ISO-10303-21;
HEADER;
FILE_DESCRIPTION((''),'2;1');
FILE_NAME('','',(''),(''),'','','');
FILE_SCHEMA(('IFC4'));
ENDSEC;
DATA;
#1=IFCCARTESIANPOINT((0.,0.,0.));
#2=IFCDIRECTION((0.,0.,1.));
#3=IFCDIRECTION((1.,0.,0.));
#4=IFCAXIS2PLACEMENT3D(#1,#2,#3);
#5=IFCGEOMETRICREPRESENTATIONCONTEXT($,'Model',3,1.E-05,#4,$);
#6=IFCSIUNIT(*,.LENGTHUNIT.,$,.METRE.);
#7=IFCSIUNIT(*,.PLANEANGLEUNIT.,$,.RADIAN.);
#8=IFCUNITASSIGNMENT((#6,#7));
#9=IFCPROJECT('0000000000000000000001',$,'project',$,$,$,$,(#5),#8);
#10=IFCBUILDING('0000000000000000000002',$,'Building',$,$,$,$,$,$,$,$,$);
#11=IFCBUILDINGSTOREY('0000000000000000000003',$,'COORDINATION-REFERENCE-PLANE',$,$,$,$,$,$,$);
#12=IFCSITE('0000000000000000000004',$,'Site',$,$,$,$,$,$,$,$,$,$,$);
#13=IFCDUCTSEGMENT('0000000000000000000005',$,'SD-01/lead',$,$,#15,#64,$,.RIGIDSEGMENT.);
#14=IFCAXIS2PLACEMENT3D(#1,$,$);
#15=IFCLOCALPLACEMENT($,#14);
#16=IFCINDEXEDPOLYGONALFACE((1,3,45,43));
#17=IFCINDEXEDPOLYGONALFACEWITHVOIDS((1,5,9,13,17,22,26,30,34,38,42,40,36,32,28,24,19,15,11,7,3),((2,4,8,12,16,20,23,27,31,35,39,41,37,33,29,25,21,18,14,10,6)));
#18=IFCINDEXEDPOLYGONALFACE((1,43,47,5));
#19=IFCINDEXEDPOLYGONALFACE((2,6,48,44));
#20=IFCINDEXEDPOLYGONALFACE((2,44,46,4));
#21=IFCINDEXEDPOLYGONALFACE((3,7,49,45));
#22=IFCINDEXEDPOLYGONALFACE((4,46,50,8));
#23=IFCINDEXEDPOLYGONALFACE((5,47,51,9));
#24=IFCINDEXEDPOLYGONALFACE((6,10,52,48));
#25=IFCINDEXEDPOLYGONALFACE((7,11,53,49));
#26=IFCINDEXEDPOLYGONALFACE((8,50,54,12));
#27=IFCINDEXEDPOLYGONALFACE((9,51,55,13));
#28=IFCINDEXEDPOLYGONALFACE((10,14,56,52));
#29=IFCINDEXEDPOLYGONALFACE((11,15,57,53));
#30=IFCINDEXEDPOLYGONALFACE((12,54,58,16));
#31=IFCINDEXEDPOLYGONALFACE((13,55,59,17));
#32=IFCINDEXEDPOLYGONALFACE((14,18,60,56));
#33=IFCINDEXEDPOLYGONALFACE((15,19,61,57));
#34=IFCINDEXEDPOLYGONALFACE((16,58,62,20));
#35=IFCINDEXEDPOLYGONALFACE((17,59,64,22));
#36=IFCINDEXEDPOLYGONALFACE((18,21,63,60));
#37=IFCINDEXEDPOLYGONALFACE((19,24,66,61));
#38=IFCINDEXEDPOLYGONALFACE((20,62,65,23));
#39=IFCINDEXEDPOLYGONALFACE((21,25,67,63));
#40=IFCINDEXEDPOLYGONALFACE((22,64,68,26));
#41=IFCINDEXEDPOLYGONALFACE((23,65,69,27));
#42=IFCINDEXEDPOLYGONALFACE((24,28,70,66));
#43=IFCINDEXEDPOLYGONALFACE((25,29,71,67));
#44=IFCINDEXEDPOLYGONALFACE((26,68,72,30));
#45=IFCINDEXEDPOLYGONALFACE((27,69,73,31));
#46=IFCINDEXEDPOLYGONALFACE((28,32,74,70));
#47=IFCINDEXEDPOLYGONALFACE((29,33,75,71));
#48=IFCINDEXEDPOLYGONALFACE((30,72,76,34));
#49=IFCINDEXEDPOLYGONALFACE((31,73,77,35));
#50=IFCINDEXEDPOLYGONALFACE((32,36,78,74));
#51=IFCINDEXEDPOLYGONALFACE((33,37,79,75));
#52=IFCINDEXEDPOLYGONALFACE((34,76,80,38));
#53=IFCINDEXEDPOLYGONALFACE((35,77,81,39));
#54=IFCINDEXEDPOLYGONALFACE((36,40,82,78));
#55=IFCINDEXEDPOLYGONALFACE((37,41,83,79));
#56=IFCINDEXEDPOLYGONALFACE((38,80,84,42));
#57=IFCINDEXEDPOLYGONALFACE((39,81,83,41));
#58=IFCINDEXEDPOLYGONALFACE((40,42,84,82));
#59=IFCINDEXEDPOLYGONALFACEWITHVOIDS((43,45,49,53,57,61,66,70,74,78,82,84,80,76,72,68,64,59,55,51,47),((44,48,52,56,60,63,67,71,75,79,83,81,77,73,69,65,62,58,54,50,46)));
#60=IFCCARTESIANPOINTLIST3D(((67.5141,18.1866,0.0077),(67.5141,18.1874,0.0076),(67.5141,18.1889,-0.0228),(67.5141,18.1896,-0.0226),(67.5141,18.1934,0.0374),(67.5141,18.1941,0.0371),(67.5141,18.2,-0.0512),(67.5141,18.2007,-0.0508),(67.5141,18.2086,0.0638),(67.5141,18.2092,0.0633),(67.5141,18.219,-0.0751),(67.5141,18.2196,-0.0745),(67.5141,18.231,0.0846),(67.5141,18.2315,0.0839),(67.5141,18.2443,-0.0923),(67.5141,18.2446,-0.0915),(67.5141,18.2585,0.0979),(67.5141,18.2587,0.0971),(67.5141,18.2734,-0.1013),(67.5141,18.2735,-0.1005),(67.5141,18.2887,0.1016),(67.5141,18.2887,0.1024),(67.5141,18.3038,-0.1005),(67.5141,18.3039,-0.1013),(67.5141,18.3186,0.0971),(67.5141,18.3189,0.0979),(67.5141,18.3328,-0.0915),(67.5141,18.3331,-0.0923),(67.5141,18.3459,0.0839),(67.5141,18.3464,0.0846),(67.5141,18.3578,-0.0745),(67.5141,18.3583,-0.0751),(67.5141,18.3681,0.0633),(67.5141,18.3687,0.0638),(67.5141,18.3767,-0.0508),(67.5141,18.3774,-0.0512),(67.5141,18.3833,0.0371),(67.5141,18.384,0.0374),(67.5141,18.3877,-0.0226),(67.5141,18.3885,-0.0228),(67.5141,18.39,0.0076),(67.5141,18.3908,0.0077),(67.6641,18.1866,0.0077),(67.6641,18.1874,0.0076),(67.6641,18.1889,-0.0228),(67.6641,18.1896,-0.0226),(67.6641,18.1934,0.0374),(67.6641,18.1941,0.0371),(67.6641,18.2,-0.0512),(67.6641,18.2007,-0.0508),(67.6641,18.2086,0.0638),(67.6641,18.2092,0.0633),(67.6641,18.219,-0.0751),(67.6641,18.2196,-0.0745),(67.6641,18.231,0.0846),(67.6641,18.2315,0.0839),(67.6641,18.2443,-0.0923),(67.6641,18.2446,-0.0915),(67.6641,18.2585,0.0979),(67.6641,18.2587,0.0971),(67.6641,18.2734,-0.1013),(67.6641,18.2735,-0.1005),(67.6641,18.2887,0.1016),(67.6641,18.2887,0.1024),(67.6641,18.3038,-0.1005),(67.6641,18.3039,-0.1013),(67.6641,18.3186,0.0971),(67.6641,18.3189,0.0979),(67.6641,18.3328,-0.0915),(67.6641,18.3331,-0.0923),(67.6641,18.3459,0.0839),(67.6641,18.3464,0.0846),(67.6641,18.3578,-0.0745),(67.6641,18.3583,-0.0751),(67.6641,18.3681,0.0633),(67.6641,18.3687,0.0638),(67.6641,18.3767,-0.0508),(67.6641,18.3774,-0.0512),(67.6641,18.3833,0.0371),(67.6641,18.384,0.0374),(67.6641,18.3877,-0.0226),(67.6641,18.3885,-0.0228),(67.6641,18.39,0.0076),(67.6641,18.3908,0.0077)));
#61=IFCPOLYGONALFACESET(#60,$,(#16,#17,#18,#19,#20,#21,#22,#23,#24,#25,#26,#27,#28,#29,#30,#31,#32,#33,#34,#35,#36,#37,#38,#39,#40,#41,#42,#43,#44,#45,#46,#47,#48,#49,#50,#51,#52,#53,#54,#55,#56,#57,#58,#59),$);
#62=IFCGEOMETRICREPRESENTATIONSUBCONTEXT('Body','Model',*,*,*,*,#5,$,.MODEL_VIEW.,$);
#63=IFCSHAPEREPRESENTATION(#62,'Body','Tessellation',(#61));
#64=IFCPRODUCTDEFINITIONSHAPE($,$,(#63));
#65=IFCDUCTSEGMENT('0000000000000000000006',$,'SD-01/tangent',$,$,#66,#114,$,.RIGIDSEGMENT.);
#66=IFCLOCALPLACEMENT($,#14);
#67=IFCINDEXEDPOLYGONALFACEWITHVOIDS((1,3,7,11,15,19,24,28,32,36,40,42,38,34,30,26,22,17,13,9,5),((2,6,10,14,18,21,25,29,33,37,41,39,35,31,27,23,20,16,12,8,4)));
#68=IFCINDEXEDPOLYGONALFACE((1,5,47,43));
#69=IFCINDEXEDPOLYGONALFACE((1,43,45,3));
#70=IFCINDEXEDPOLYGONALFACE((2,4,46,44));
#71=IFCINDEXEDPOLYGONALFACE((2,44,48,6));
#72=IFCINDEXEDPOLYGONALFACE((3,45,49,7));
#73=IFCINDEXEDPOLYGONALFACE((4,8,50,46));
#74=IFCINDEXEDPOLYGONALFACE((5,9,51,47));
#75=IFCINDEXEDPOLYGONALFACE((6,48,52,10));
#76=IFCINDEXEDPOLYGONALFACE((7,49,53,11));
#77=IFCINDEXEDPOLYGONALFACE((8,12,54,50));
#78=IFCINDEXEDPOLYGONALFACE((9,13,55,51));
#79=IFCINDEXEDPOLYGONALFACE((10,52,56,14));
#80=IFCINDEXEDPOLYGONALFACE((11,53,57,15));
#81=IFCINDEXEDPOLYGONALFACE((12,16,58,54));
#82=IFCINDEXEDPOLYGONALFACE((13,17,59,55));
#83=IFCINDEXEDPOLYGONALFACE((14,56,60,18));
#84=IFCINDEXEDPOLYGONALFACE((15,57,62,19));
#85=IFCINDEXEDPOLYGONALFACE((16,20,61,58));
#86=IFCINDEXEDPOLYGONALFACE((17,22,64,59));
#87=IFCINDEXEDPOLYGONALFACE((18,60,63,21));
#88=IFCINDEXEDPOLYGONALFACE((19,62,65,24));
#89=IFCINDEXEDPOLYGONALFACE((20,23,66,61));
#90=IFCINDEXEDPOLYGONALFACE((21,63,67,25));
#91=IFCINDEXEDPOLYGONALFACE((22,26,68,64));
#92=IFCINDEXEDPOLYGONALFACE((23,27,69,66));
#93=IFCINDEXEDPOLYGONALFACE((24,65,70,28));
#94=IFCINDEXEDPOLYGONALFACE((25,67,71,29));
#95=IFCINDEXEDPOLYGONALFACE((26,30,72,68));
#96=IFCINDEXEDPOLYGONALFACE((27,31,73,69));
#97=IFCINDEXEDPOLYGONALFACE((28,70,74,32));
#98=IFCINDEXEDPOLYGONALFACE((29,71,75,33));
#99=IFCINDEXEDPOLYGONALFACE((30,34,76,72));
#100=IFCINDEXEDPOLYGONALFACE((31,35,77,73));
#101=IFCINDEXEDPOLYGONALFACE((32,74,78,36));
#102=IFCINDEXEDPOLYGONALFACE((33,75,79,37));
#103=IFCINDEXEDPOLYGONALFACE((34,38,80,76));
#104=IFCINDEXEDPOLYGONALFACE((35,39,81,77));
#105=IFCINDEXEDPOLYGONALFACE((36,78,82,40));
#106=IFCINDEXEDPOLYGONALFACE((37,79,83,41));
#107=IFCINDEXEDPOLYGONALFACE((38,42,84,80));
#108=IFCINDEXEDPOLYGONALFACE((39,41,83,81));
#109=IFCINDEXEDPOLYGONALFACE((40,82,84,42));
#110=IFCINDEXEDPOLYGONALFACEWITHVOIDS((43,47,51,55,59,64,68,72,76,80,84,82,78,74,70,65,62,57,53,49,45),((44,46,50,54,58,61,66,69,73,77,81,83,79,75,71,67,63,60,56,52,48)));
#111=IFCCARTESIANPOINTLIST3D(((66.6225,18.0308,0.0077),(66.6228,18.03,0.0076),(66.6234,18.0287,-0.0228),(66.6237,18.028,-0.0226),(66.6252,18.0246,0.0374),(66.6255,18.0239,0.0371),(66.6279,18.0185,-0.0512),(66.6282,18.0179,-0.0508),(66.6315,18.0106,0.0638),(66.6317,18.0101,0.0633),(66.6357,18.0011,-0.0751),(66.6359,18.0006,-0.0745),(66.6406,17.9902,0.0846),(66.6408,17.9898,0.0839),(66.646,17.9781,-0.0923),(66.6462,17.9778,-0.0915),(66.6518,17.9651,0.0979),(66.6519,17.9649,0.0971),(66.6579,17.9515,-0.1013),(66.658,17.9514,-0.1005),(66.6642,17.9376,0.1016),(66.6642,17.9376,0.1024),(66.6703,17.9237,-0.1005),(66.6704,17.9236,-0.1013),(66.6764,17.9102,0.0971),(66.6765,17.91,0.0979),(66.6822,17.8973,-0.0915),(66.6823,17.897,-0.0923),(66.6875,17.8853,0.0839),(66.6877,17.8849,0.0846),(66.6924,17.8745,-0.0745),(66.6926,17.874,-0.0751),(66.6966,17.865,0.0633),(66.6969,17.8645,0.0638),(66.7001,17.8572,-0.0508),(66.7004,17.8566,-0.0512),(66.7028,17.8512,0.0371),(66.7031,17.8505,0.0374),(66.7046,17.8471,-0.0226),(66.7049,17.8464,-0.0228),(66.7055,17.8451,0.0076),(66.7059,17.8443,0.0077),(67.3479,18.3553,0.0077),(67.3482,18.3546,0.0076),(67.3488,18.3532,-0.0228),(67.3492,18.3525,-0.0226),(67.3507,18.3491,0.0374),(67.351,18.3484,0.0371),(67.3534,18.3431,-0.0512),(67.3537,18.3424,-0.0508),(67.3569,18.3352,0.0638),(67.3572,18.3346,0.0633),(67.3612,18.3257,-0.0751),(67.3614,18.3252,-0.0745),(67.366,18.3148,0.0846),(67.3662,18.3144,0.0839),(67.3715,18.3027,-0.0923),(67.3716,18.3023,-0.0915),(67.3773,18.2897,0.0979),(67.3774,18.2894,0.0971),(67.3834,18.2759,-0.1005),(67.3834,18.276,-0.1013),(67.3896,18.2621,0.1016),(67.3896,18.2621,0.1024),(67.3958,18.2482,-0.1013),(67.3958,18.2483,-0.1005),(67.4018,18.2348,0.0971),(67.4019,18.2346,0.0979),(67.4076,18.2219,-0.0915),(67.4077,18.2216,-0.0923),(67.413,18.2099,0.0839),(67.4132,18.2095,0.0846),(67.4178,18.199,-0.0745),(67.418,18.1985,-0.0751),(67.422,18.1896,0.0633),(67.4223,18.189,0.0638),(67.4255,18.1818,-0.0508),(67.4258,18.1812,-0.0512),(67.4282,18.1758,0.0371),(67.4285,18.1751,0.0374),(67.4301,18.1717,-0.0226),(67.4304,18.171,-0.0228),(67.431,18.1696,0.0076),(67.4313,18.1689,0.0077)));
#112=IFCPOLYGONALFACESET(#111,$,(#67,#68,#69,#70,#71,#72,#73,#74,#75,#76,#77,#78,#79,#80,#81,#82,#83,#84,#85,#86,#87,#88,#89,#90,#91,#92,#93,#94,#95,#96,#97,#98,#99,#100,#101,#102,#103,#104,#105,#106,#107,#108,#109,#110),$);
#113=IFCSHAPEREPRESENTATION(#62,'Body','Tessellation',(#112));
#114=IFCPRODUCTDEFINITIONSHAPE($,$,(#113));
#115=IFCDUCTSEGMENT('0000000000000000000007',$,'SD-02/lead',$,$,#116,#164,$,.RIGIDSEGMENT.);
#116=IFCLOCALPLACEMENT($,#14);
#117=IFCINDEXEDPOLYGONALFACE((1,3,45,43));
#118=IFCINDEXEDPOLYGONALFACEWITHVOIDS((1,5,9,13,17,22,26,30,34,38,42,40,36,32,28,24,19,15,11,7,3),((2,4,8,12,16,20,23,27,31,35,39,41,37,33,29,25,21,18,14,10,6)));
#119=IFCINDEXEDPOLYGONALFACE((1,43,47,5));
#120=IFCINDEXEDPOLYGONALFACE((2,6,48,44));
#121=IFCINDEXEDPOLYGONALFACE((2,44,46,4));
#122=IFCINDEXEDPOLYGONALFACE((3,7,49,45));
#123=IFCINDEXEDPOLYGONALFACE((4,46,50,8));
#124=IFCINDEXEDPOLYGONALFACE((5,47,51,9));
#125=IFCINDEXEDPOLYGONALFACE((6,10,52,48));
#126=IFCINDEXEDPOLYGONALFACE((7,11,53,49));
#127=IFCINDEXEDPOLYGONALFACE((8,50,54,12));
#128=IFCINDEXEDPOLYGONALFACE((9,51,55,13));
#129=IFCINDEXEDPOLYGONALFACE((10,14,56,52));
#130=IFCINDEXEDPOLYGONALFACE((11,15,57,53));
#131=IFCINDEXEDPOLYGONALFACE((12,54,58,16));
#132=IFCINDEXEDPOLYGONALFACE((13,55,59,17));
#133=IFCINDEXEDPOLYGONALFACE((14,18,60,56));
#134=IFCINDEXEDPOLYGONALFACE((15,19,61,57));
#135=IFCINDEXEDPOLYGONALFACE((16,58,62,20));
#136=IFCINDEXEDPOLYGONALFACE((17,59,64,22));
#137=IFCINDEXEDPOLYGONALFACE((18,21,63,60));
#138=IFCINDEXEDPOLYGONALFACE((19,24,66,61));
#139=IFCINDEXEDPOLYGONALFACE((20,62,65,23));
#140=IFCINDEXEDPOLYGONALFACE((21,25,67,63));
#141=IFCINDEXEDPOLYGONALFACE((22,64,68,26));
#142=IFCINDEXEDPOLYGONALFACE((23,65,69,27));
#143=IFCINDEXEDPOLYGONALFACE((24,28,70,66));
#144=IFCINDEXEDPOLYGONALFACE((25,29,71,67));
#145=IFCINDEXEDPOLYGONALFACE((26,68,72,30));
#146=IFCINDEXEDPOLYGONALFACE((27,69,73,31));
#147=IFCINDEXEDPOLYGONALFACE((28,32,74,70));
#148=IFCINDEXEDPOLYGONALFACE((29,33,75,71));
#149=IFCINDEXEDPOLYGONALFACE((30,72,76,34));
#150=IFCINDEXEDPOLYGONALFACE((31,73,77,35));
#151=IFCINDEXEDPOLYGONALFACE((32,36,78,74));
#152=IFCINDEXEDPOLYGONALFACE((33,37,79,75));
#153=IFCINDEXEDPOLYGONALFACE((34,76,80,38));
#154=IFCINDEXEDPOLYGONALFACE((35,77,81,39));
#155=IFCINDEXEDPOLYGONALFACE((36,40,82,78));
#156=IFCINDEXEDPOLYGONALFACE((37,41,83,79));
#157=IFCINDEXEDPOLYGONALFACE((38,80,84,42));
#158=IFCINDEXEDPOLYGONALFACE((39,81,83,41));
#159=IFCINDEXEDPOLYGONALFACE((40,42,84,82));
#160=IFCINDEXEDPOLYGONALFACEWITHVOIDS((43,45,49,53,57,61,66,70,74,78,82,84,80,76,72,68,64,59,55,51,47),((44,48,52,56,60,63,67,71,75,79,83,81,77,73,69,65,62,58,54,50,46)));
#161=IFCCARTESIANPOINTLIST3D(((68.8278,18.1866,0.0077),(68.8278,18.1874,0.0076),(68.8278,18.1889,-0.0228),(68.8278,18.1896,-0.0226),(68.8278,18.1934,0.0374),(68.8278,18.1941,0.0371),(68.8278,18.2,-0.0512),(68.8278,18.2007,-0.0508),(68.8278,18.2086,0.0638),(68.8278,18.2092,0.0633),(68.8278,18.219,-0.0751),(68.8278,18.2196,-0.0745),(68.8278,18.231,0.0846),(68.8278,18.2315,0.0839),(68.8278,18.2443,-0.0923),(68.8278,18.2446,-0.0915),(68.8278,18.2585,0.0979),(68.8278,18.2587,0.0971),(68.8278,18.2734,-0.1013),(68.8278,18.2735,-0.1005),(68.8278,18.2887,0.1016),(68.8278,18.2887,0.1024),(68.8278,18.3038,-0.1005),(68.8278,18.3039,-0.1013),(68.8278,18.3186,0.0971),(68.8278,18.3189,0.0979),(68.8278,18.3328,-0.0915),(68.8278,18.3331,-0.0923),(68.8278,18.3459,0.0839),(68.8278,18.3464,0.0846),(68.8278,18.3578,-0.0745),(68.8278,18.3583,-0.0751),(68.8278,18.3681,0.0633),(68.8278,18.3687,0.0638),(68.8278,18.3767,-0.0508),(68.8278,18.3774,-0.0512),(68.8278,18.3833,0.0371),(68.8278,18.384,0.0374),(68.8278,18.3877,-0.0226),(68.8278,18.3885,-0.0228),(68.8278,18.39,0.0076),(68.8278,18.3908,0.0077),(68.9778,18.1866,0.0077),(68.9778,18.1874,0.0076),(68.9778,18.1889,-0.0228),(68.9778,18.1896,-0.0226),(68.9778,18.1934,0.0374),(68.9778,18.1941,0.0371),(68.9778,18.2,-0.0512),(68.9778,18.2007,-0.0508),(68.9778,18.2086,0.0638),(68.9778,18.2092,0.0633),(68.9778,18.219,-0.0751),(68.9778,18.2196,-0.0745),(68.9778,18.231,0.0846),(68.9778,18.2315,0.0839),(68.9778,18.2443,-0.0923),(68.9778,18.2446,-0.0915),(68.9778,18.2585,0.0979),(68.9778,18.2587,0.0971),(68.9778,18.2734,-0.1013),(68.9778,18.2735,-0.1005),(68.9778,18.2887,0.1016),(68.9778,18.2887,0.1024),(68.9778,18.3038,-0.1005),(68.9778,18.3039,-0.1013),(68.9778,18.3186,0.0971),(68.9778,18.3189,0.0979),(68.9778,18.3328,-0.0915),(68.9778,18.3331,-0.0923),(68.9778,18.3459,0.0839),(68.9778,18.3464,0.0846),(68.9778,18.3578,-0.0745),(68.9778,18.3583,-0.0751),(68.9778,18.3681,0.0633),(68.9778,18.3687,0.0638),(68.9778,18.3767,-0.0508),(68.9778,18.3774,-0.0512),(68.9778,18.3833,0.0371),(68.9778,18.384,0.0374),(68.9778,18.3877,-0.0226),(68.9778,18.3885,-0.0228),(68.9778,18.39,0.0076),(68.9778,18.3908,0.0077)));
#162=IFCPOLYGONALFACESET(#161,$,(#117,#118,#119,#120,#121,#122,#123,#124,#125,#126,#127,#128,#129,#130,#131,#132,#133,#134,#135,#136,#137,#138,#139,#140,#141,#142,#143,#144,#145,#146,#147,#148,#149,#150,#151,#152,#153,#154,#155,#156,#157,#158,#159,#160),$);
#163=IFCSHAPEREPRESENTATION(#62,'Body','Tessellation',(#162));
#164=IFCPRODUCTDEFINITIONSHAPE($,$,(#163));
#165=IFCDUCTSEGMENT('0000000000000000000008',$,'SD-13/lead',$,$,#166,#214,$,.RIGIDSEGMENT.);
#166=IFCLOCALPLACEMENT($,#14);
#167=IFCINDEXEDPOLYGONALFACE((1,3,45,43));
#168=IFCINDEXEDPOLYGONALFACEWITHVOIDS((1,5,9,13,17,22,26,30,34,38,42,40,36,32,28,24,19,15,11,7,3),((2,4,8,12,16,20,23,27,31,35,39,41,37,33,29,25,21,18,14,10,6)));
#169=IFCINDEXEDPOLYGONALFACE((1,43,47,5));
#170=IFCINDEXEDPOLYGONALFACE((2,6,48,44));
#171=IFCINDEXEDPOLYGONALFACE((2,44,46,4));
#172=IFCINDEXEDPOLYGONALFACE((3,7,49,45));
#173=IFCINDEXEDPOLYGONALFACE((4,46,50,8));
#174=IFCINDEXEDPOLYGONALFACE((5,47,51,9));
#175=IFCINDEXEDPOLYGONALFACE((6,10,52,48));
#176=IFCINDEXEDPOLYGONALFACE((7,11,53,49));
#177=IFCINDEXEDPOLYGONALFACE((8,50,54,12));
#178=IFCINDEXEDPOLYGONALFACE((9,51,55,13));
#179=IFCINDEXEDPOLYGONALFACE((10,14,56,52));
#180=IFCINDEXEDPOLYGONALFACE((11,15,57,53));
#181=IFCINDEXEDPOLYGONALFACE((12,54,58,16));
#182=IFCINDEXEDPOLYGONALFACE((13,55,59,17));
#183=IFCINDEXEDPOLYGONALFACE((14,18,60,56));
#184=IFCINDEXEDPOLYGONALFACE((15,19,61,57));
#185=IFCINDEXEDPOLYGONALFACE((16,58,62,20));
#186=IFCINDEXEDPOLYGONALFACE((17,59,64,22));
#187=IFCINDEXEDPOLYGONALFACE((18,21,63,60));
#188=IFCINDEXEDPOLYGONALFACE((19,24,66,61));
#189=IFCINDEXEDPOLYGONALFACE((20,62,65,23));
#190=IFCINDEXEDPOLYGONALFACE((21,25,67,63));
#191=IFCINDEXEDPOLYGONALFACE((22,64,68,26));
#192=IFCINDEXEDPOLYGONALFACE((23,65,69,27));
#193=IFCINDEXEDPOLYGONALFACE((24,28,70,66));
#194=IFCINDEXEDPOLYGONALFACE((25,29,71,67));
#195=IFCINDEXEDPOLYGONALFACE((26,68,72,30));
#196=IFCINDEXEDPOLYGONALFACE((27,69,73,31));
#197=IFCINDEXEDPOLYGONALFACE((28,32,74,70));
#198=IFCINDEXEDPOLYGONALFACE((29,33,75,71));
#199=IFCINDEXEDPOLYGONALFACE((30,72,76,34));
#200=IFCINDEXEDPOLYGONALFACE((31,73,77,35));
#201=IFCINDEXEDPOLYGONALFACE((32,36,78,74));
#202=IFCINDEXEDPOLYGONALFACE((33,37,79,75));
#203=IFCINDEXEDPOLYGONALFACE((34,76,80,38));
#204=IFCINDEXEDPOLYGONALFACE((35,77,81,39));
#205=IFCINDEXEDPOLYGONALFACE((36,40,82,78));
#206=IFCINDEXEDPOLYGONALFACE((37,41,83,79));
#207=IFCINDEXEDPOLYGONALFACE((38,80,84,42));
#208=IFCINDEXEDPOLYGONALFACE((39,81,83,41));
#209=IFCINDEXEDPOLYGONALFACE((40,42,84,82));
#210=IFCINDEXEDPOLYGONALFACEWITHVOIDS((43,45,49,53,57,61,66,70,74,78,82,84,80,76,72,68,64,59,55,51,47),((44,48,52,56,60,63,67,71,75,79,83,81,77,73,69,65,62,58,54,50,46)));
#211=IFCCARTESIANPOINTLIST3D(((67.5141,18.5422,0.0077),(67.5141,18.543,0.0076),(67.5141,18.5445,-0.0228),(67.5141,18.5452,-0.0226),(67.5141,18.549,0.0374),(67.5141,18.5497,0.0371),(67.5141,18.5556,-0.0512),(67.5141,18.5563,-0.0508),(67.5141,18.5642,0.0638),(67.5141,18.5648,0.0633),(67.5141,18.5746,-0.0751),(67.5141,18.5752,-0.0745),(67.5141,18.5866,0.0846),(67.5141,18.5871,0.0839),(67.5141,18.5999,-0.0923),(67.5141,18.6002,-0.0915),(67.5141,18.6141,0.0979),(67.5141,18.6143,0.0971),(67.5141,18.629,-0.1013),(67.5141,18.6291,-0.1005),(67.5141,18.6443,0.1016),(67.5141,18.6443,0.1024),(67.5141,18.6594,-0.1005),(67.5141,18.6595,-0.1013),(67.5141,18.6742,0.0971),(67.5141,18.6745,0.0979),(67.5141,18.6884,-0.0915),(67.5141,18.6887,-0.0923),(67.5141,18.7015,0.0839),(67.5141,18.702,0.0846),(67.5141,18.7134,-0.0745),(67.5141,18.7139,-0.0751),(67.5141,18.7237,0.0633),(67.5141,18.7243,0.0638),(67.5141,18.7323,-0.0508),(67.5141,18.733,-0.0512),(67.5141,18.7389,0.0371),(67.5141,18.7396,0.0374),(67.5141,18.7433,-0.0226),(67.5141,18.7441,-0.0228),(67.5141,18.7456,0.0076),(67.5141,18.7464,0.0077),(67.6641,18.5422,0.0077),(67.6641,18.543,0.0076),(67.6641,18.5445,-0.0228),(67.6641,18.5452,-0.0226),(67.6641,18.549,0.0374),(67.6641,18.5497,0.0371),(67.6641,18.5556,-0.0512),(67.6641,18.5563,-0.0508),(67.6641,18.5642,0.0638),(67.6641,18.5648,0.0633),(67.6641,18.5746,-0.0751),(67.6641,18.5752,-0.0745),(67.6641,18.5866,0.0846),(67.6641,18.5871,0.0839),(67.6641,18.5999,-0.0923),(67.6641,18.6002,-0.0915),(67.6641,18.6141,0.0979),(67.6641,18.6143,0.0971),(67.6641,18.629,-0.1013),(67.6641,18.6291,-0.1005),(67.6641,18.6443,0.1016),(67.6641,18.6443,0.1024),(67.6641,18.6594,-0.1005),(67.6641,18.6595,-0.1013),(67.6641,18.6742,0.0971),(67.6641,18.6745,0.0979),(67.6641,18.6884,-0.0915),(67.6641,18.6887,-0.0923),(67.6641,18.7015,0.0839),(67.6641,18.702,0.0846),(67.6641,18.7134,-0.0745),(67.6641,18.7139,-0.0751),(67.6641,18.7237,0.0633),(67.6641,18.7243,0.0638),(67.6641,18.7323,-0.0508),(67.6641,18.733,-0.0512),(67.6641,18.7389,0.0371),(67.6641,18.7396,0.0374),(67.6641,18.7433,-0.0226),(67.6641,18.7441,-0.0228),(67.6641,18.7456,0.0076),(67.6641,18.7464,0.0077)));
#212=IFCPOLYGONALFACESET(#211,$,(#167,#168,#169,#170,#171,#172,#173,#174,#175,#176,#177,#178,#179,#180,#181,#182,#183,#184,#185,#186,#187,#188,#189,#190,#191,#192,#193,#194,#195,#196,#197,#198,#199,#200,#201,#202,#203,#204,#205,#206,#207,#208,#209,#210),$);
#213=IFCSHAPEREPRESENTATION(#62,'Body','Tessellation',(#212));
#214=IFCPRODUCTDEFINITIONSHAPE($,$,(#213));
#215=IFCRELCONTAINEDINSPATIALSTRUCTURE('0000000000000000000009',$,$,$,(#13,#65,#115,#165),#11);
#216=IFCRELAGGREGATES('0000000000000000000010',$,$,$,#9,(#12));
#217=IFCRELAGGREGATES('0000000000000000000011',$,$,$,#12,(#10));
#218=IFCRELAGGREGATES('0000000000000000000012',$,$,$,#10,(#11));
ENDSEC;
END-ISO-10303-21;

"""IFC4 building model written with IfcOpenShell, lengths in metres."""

from ifc_helpers import new_model, si_unit, frame, origin_with_axes, place, context, subcontext, project, spatial, hollow_circle, extrude, element, save


model = new_model("IFC4")

# Units and contexts
model_context = context("Model", 3, precision=1e-05, world=origin_with_axes())
body_context_1 = subcontext(model_context, "Body", "Model", "MODEL_VIEW")
ifc_project = project(units=[si_unit("LENGTHUNIT", "METRE"), si_unit("PLANEANGLEUNIT", "RADIAN")], contexts=[model_context])

# Site, building, storey
site = spatial("IfcSite", under=ifc_project, Name="Site")
building = spatial("IfcBuilding", under=site, Name="Building")
storey = spatial("IfcBuildingStorey", under=building, Name="COORDINATION-REFERENCE-PLANE")

# Duct segment
duct_segment_1_placement = place(None, frame((67.6641, 18.2887, 0.0), z_axis=(-1.0, 0.0, 0.0), x_axis=(0.0, 0.0, 1.0)))
element("IfcDuctSegment", 1, at=duct_segment_1_placement, inside=storey, Name="SD-01/lead", PredefinedType="RIGIDSEGMENT", context=body_context_1, shape_type="SweptSolid", body=[
    extrude(hollow_circle(Radius=0.1024, WallThickness=0.0008), origin_with_axes(), (0.0, 0.0, 1.0), 0.15),
])

# Duct segment
duct_segment_2_placement = place(None, frame((67.3896, 18.2621, 0.0), z_axis=(-0.912813, -0.408378, 0.0), x_axis=(0.0, 0.0, 1.0)))
element("IfcDuctSegment", 2, at=duct_segment_2_placement, inside=storey, Name="SD-01/tangent", PredefinedType="RIGIDSEGMENT", context=body_context_1, shape_type="SweptSolid", body=[
    extrude(hollow_circle(Radius=0.1024, WallThickness=0.0008), origin_with_axes(), (0.0, 0.0, 1.0), 0.7947),
])

# Duct segment
duct_segment_3_placement = place(None, frame((68.8278, 18.2887, 0.0), z_axis=(1.0, 0.0, 0.0), x_axis=(0.0, 0.0, 1.0)))
element("IfcDuctSegment", 3, at=duct_segment_3_placement, inside=storey, Name="SD-02/lead", PredefinedType="RIGIDSEGMENT", context=body_context_1, shape_type="SweptSolid", body=[
    extrude(hollow_circle(Radius=0.1024, WallThickness=0.0008), origin_with_axes(), (0.0, 0.0, 1.0), 0.15),
])

# Duct segment
duct_segment_4_placement = place(None, frame((67.6641, 18.6443, 0.0), z_axis=(-1.0, 0.0, 0.0), x_axis=(0.0, 0.0, 1.0)))
element("IfcDuctSegment", 4, at=duct_segment_4_placement, inside=storey, Name="SD-13/lead", PredefinedType="RIGIDSEGMENT", context=body_context_1, shape_type="SweptSolid", body=[
    extrude(hollow_circle(Radius=0.1024, WallThickness=0.0008), origin_with_axes(), (0.0, 0.0, 1.0), 0.15),
])

save(model, "model.ifc")
